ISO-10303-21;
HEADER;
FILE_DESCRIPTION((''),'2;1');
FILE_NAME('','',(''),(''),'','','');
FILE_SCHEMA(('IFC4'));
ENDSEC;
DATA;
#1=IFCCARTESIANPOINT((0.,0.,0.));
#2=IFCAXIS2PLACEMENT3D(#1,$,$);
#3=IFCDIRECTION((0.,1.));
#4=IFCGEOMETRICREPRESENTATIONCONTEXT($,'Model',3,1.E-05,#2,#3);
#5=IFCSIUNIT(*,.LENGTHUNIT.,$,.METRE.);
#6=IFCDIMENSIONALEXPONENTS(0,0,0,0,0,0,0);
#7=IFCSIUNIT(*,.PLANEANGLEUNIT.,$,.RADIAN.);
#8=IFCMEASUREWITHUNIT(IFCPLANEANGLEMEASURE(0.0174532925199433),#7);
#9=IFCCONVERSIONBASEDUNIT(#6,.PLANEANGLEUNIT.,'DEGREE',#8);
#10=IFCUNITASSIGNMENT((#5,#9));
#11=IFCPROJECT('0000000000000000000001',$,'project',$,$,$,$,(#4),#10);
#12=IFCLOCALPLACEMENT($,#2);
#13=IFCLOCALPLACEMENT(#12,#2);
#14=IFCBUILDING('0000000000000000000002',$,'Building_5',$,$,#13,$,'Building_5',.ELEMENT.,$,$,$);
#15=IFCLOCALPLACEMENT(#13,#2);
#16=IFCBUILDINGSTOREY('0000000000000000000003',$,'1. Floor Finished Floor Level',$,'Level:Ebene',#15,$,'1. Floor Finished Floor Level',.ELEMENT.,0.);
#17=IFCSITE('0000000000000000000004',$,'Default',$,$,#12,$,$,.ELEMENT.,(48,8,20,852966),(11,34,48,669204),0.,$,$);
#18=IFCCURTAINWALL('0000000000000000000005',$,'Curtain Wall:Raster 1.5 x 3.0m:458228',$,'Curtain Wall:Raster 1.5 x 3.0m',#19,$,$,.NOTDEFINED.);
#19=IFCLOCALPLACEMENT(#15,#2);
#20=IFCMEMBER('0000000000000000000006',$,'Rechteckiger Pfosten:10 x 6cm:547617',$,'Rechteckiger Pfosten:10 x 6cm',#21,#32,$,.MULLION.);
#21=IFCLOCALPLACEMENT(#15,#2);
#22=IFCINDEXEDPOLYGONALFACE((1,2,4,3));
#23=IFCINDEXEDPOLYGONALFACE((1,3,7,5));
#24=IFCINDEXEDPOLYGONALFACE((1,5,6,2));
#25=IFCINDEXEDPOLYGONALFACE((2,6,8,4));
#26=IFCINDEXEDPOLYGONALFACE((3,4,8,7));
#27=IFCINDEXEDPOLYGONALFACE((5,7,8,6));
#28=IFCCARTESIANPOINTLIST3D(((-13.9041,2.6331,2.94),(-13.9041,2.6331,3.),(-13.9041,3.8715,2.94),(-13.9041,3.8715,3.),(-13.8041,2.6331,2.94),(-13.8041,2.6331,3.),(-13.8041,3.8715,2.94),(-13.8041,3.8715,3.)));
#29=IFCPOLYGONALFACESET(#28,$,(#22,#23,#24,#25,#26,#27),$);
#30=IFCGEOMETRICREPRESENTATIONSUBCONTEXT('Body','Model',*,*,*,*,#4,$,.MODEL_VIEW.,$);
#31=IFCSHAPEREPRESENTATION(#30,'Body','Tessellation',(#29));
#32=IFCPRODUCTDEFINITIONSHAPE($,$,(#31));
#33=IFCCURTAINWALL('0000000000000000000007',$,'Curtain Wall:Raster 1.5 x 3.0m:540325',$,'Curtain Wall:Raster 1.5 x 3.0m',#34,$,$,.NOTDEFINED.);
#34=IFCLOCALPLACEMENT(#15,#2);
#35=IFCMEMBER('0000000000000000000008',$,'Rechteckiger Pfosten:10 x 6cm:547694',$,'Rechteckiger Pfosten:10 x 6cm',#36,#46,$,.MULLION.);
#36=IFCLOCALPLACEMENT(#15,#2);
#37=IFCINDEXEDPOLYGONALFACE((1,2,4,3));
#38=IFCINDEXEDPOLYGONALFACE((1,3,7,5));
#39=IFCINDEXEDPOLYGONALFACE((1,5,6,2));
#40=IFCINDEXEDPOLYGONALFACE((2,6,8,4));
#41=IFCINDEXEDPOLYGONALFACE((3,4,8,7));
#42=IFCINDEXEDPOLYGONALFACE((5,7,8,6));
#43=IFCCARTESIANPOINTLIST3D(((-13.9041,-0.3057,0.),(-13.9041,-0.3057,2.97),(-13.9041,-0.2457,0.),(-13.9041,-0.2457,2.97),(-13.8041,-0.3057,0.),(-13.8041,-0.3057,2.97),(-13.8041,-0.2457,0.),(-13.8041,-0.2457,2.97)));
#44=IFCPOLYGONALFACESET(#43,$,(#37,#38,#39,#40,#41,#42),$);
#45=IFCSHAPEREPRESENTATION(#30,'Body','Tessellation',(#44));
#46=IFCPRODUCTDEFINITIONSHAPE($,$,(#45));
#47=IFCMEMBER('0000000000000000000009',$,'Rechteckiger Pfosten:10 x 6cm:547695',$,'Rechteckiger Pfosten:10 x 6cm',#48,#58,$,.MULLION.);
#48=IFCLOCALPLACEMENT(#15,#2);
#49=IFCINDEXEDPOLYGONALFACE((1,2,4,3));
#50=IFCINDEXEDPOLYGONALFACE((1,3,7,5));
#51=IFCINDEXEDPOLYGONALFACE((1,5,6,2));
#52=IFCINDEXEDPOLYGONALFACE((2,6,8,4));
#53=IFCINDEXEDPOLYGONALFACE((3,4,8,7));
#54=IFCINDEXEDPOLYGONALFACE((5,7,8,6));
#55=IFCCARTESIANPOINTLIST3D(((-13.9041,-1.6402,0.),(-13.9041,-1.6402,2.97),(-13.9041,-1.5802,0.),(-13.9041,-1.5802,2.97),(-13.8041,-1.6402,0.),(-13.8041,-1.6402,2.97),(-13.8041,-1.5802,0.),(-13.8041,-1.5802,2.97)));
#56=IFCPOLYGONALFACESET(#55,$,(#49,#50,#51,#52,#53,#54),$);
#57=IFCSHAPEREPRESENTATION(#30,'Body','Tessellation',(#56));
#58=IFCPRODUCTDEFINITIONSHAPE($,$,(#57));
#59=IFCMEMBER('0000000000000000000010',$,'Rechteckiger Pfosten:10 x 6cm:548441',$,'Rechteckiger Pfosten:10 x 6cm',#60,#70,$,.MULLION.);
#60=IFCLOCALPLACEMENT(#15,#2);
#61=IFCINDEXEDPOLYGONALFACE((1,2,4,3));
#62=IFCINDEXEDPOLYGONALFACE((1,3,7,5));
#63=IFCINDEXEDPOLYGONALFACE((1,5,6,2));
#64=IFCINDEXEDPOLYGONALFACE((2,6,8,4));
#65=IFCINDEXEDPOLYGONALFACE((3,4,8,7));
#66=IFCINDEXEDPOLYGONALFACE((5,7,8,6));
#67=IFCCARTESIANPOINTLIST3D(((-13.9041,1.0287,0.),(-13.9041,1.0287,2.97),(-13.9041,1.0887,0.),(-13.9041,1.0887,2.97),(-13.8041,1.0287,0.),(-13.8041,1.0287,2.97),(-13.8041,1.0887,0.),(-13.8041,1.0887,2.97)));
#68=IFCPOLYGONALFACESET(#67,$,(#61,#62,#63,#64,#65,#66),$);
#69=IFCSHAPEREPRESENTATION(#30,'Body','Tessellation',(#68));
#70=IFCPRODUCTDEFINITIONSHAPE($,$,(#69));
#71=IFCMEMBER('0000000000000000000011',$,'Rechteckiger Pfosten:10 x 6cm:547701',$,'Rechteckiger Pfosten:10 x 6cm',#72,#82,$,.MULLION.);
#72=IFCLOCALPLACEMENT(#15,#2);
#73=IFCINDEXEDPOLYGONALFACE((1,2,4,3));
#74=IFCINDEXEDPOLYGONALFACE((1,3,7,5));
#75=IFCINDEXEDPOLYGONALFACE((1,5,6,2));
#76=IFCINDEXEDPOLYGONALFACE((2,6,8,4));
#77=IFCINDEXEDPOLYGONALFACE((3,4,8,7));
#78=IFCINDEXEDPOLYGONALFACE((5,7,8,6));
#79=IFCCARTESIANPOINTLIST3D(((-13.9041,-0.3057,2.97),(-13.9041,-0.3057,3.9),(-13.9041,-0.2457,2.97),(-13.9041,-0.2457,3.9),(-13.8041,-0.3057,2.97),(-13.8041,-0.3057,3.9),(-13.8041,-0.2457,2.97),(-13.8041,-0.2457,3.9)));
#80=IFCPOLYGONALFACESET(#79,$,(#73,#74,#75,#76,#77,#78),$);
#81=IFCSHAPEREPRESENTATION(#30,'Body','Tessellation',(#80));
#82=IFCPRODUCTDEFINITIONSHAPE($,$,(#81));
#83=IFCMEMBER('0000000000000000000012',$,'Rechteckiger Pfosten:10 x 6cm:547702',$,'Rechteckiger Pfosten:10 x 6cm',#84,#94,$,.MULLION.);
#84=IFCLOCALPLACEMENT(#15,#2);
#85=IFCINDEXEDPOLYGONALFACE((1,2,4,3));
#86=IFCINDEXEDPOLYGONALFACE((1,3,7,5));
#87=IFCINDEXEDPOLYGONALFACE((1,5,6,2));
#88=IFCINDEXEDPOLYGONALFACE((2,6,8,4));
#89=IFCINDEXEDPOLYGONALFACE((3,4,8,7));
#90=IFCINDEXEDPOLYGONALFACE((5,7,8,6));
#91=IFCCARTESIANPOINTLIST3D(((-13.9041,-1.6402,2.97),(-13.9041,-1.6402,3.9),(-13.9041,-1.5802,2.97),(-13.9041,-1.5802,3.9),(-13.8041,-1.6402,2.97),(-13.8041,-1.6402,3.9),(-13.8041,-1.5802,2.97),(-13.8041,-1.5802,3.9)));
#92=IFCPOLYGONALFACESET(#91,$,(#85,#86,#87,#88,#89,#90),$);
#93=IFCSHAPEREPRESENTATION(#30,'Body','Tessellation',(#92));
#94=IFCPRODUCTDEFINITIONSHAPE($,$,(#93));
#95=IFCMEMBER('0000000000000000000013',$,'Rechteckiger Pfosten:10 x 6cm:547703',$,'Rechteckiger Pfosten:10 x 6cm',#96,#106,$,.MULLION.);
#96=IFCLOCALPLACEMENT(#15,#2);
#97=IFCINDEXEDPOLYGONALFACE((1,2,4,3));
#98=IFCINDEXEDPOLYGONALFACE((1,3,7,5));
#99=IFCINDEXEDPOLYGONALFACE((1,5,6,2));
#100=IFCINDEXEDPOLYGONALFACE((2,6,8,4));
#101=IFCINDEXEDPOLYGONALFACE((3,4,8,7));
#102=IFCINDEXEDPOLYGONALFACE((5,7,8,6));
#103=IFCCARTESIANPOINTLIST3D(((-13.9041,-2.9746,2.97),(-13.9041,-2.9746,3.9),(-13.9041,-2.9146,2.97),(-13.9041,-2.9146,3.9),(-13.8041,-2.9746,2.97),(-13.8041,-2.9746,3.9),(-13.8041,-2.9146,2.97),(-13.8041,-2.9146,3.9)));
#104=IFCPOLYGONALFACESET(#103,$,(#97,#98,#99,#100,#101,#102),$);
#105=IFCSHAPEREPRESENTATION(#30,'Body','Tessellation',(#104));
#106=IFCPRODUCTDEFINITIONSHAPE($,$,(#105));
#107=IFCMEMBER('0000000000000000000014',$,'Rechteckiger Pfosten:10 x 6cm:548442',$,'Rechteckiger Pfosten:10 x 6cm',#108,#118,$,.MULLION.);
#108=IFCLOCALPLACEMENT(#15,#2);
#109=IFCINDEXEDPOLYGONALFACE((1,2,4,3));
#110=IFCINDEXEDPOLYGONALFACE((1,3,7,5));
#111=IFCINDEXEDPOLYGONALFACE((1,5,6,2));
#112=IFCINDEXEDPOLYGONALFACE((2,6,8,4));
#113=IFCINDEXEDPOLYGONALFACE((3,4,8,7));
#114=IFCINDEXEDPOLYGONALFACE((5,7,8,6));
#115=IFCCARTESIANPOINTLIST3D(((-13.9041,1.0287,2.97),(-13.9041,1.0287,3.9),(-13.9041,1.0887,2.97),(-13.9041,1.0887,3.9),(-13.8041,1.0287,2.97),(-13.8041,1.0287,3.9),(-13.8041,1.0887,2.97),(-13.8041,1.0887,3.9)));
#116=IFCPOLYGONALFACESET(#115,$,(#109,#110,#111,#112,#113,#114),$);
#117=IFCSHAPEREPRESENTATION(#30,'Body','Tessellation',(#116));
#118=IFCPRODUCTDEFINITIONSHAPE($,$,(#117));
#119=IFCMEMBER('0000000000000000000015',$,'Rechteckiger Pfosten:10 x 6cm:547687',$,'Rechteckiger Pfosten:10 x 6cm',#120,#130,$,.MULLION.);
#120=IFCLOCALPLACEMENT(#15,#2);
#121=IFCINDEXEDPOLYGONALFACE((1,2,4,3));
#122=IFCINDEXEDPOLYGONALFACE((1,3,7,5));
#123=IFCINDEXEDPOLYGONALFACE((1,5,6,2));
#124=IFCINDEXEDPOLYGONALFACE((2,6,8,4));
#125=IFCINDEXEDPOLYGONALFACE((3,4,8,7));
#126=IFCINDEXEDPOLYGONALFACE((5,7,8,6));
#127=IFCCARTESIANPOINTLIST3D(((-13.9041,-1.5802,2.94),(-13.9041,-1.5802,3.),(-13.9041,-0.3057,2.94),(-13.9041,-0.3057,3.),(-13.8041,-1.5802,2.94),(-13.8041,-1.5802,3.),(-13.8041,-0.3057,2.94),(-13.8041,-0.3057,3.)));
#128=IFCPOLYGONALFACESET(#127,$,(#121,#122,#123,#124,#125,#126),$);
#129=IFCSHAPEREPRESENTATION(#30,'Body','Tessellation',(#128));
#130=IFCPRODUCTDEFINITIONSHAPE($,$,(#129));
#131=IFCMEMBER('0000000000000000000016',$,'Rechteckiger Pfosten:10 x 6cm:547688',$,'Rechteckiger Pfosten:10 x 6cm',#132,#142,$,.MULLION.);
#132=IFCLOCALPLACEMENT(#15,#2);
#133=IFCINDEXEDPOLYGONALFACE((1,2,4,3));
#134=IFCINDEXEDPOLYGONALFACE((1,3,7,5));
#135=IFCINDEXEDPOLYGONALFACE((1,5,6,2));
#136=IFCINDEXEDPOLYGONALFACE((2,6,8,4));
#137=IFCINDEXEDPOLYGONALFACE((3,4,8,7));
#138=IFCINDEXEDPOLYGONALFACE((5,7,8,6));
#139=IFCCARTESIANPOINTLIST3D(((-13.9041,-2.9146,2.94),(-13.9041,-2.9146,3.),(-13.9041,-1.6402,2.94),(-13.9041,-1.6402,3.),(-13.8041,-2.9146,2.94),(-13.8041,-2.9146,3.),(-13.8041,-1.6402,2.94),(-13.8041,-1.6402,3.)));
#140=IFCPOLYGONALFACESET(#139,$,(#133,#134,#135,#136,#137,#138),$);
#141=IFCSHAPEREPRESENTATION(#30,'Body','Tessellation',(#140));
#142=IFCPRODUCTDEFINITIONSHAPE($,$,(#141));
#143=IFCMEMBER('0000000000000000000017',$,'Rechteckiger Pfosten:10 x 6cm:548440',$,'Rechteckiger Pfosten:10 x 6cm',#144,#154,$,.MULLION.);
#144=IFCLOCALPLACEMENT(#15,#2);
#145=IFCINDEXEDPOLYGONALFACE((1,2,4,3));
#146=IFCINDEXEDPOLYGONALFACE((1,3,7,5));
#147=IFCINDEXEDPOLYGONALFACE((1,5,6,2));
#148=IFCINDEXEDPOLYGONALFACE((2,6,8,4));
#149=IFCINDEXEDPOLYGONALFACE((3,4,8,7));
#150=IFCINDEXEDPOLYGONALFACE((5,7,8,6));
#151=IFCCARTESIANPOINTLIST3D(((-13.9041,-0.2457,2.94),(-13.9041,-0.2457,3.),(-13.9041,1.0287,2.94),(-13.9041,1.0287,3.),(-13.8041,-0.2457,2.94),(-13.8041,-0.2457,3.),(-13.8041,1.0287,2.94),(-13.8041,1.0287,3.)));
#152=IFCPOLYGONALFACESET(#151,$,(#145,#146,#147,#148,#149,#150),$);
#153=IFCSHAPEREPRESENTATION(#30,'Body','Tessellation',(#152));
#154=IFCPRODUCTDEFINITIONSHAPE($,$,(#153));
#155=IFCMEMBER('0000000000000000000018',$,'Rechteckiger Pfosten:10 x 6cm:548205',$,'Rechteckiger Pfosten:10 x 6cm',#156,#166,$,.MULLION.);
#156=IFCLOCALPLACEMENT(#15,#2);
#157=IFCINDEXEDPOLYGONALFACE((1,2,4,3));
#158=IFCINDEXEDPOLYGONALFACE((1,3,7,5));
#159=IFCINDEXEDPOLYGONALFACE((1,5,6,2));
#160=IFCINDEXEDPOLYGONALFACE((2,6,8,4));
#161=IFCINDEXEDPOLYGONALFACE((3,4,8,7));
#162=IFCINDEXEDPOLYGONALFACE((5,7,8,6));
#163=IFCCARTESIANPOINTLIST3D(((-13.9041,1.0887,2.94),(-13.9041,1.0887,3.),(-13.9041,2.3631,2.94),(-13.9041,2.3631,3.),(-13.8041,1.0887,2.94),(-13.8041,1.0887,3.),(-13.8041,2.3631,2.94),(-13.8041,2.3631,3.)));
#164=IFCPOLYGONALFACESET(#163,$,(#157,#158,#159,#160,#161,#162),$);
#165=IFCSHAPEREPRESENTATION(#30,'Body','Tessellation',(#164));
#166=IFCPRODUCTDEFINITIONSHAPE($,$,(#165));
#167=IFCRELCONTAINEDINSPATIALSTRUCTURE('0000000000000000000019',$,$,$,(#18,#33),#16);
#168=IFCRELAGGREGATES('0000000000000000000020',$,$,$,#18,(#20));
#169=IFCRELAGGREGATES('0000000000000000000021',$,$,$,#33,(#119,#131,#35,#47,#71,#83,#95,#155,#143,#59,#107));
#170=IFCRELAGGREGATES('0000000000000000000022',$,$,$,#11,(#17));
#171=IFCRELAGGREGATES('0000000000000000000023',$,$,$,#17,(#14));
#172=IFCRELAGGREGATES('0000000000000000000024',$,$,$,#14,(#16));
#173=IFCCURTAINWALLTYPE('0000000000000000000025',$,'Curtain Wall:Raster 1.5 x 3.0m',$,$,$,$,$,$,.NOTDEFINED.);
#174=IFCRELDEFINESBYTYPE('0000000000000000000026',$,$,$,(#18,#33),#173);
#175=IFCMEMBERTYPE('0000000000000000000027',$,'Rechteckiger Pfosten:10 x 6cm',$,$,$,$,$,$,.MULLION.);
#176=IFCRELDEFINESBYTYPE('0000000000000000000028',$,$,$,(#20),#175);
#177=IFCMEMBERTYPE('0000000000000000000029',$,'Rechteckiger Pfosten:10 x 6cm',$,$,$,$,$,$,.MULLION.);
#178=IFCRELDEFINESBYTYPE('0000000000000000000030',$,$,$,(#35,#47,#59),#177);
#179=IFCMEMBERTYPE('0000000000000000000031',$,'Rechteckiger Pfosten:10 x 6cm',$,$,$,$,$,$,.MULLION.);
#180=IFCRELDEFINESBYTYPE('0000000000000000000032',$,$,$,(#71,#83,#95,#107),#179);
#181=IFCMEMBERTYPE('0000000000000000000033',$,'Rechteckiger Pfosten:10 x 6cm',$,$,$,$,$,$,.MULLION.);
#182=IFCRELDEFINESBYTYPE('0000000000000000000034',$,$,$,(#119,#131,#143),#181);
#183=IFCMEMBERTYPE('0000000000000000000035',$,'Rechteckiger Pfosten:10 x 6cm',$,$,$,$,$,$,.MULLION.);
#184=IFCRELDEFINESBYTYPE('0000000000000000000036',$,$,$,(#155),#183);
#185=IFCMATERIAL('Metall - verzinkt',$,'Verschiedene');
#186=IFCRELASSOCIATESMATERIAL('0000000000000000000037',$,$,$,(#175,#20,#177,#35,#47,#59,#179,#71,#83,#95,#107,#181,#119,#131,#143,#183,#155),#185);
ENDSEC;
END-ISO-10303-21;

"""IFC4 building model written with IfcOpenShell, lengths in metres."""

from ifc_helpers import new_model, entity, si_unit, converted_unit, direction, frame, origin, place, context, subcontext, project, spatial, indexed_curve, outline, extrude, source, transform, mapped, material, type_object, type_shapes, element, aggregate, save


model = new_model("IFC4")

# Units and contexts
model_context = context("Model", 3, precision=1e-05, world=origin(), true_north=direction((0.0, 1.0)))
body_context = subcontext(model_context, "Body", "Model", "MODEL_VIEW")
ifc_project = project(units=[si_unit("LENGTHUNIT", "METRE"), converted_unit("PLANEANGLEUNIT", "DEGREE", entity("IfcPlaneAngleMeasure", 0.0174532925199433), si_unit("PLANEANGLEUNIT", "RADIAN"), dimensions=[0, 0, 0, 0, 0, 0, 0])], contexts=[model_context])

# Site, building, storey
site_placement = place(None, origin())
site = spatial("IfcSite", under=ifc_project, at=site_placement, Name="Default", CompositionType="ELEMENT", RefLatitude=(48, 8, 20, 852966), RefLongitude=(11, 34, 48, 669204), RefElevation=0.0)
building_placement = place(site_placement, origin())
building = spatial("IfcBuilding", under=site, at=building_placement, Name="Building_5", LongName="Building_5", CompositionType="ELEMENT")
storey_placement = place(building_placement, origin())
storey = spatial("IfcBuildingStorey", under=building, at=storey_placement, Name="1. Floor Finished Floor Level", ObjectType="Level:Ebene", LongName="1. Floor Finished Floor Level", CompositionType="ELEMENT", Elevation=0.0)

# Curtain wall, member
curtain_wall_type = type_object("IfcCurtainWallType", Name="Curtain Wall:Raster 1.5 x 3.0m", PredefinedType="NOTDEFINED")
curtain_wall_1_placement = place(storey_placement, origin())
curtain_wall_1 = element("IfcCurtainWall", 1, at=curtain_wall_1_placement, inside=storey, type_object=curtain_wall_type, Name="Curtain Wall:Raster 1.5 x 3.0m:458228", ObjectType="Curtain Wall:Raster 1.5 x 3.0m", PredefinedType="NOTDEFINED")
ifc_material_1 = material(Name="Metall - verzinkt", Category="Verschiedene")
member_type_1 = type_object("IfcMemberType", Name="Rechteckiger Pfosten:10 x 6cm", PredefinedType="MULLION", material=ifc_material_1)
shared_shape_1 = source(origin(), body_context, "Body", "SweptSolid", [
    extrude(outline(indexed_curve([(-0.03, -0.05), (0.03, -0.05), (0.03, 0.05), (-0.03, 0.05), (-0.03, -0.05)], self_intersect=False)), frame((0.0, 0.0, -1.2383), z_axis=(0.0, 0.0, 1.0), x_axis=(-1.0, 0.0, 0.0)), (0.0, 0.0, 1.0), 1.2383),
])
type_shapes(member_type_1, [shared_shape_1])
member_1_placement = place(curtain_wall_1_placement, frame((-13.8541, 2.6331, 2.97), z_axis=(0.0, -1.0, 0.0), x_axis=(0.0, 0.0, 1.0)))
member_1 = element("IfcMember", 2, at=member_1_placement, type_object=member_type_1, material=ifc_material_1, Name="Rechteckiger Pfosten:10 x 6cm:547617", ObjectType="Rechteckiger Pfosten:10 x 6cm", PredefinedType="MULLION", context=body_context, shape_type="MappedRepresentation", body=[
    mapped(shared_shape_1, transform((0.0, 0.0, 0.0), scale=1.0)),
])

# Curtain wall, members
curtain_wall_2_placement = place(storey_placement, origin())
curtain_wall_2 = element("IfcCurtainWall", 3, at=curtain_wall_2_placement, inside=storey, type_object=curtain_wall_type, Name="Curtain Wall:Raster 1.5 x 3.0m:540325", ObjectType="Curtain Wall:Raster 1.5 x 3.0m", PredefinedType="NOTDEFINED")
member_type_2 = type_object("IfcMemberType", Name="Rechteckiger Pfosten:10 x 6cm", PredefinedType="MULLION", material=ifc_material_1)
shared_shape_2 = source(origin(), body_context, "Body", "SweptSolid", [
    extrude(outline(indexed_curve([(-0.03, -0.05), (0.03, -0.05), (0.03, 0.05), (-0.03, 0.05), (-0.03, -0.05)], self_intersect=False)), frame((0.0, 0.0, -2.97), z_axis=(0.0, 0.0, 1.0), x_axis=(-1.0, 0.0, 0.0)), (0.0, 0.0, 1.0), 2.97),
])
type_shapes(member_type_2, [shared_shape_2])
member_2_placement = place(curtain_wall_2_placement, frame((-13.8541, -0.2757, 0.0), z_axis=(0.0, 0.0, -1.0), x_axis=(0.0, -1.0, 0.0)))
member_2 = element("IfcMember", 4, at=member_2_placement, type_object=member_type_2, material=ifc_material_1, Name="Rechteckiger Pfosten:10 x 6cm:547694", ObjectType="Rechteckiger Pfosten:10 x 6cm", PredefinedType="MULLION", context=body_context, shape_type="MappedRepresentation", body=[
    mapped(shared_shape_2, transform((0.0, 0.0, 0.0), scale=1.0)),
])
member_3_placement = place(curtain_wall_2_placement, frame((-13.8541, -1.6102, 0.0), z_axis=(0.0, 0.0, -1.0), x_axis=(0.0, -1.0, 0.0)))
member_3 = element("IfcMember", 5, at=member_3_placement, type_object=member_type_2, material=ifc_material_1, Name="Rechteckiger Pfosten:10 x 6cm:547695", ObjectType="Rechteckiger Pfosten:10 x 6cm", PredefinedType="MULLION", context=body_context, shape_type="MappedRepresentation", body=[
    mapped(shared_shape_2, transform((0.0, 0.0, 0.0), scale=1.0)),
])
member_4_placement = place(curtain_wall_2_placement, frame((-13.8541, 1.0587, 0.0), z_axis=(0.0, 0.0, -1.0), x_axis=(0.0, -1.0, 0.0)))
member_4 = element("IfcMember", 6, at=member_4_placement, type_object=member_type_2, material=ifc_material_1, Name="Rechteckiger Pfosten:10 x 6cm:548441", ObjectType="Rechteckiger Pfosten:10 x 6cm", PredefinedType="MULLION", context=body_context, shape_type="MappedRepresentation", body=[
    mapped(shared_shape_2, transform((0.0, 0.0, 0.0), scale=1.0)),
])
member_type_3 = type_object("IfcMemberType", Name="Rechteckiger Pfosten:10 x 6cm", PredefinedType="MULLION", material=ifc_material_1)
shared_shape_3 = source(origin(), body_context, "Body", "SweptSolid", [
    extrude(outline(indexed_curve([(-0.03, -0.05), (0.03, -0.05), (0.03, 0.05), (-0.03, 0.05), (-0.03, -0.05)], self_intersect=False)), frame((0.0, 0.0, -0.93), z_axis=(0.0, 0.0, 1.0), x_axis=(-1.0, 0.0, 0.0)), (0.0, 0.0, 1.0), 0.93),
])
type_shapes(member_type_3, [shared_shape_3])
member_5_placement = place(curtain_wall_2_placement, frame((-13.8541, -0.2757, 2.97), z_axis=(0.0, 0.0, -1.0), x_axis=(0.0, -1.0, 0.0)))
member_5 = element("IfcMember", 7, at=member_5_placement, type_object=member_type_3, material=ifc_material_1, Name="Rechteckiger Pfosten:10 x 6cm:547701", ObjectType="Rechteckiger Pfosten:10 x 6cm", PredefinedType="MULLION", context=body_context, shape_type="MappedRepresentation", body=[
    mapped(shared_shape_3, transform((0.0, 0.0, 0.0), scale=1.0)),
])
member_6_placement = place(curtain_wall_2_placement, frame((-13.8541, -1.6102, 2.97), z_axis=(0.0, 0.0, -1.0), x_axis=(0.0, -1.0, 0.0)))
member_6 = element("IfcMember", 8, at=member_6_placement, type_object=member_type_3, material=ifc_material_1, Name="Rechteckiger Pfosten:10 x 6cm:547702", ObjectType="Rechteckiger Pfosten:10 x 6cm", PredefinedType="MULLION", context=body_context, shape_type="MappedRepresentation", body=[
    mapped(shared_shape_3, transform((0.0, 0.0, 0.0), scale=1.0)),
])
member_7_placement = place(curtain_wall_2_placement, frame((-13.8541, -2.9446, 2.97), z_axis=(0.0, 0.0, -1.0), x_axis=(0.0, -1.0, 0.0)))
member_7 = element("IfcMember", 9, at=member_7_placement, type_object=member_type_3, material=ifc_material_1, Name="Rechteckiger Pfosten:10 x 6cm:547703", ObjectType="Rechteckiger Pfosten:10 x 6cm", PredefinedType="MULLION", context=body_context, shape_type="MappedRepresentation", body=[
    mapped(shared_shape_3, transform((0.0, 0.0, 0.0), scale=1.0)),
])
member_8_placement = place(curtain_wall_2_placement, frame((-13.8541, 1.0587, 2.97), z_axis=(0.0, 0.0, -1.0), x_axis=(0.0, -1.0, 0.0)))
member_8 = element("IfcMember", 10, at=member_8_placement, type_object=member_type_3, material=ifc_material_1, Name="Rechteckiger Pfosten:10 x 6cm:548442", ObjectType="Rechteckiger Pfosten:10 x 6cm", PredefinedType="MULLION", context=body_context, shape_type="MappedRepresentation", body=[
    mapped(shared_shape_3, transform((0.0, 0.0, 0.0), scale=1.0)),
])
member_type_4 = type_object("IfcMemberType", Name="Rechteckiger Pfosten:10 x 6cm", PredefinedType="MULLION", material=ifc_material_1)
shared_shape_4 = source(origin(), body_context, "Body", "SweptSolid", [
    extrude(outline(indexed_curve([(-0.03, -0.05), (0.03, -0.05), (0.03, 0.05), (-0.03, 0.05), (-0.03, -0.05)], self_intersect=False)), frame((0.0, 0.0, -1.2744), z_axis=(0.0, 0.0, 1.0), x_axis=(-1.0, 0.0, 0.0)), (0.0, 0.0, 1.0), 1.2744),
])
type_shapes(member_type_4, [shared_shape_4])
member_9_placement = place(curtain_wall_2_placement, frame((-13.8541, -1.5802, 2.97), z_axis=(0.0, -1.0, 0.0), x_axis=(0.0, 0.0, 1.0)))
member_9 = element("IfcMember", 11, at=member_9_placement, type_object=member_type_4, material=ifc_material_1, Name="Rechteckiger Pfosten:10 x 6cm:547687", ObjectType="Rechteckiger Pfosten:10 x 6cm", PredefinedType="MULLION", context=body_context, shape_type="MappedRepresentation", body=[
    mapped(shared_shape_4, transform((0.0, 0.0, 0.0), scale=1.0)),
])
member_10_placement = place(curtain_wall_2_placement, frame((-13.8541, -2.9146, 2.97), z_axis=(0.0, -1.0, 0.0), x_axis=(0.0, 0.0, 1.0)))
member_10 = element("IfcMember", 12, at=member_10_placement, type_object=member_type_4, material=ifc_material_1, Name="Rechteckiger Pfosten:10 x 6cm:547688", ObjectType="Rechteckiger Pfosten:10 x 6cm", PredefinedType="MULLION", context=body_context, shape_type="MappedRepresentation", body=[
    mapped(shared_shape_4, transform((0.0, 0.0, 0.0), scale=1.0)),
])
member_11_placement = place(curtain_wall_2_placement, frame((-13.8541, -0.2457, 2.97), z_axis=(0.0, -1.0, 0.0), x_axis=(0.0, 0.0, 1.0)))
member_11 = element("IfcMember", 13, at=member_11_placement, type_object=member_type_4, material=ifc_material_1, Name="Rechteckiger Pfosten:10 x 6cm:548440", ObjectType="Rechteckiger Pfosten:10 x 6cm", PredefinedType="MULLION", context=body_context, shape_type="MappedRepresentation", body=[
    mapped(shared_shape_4, transform((0.0, 0.0, 0.0), scale=1.0)),
])
member_type_5 = type_object("IfcMemberType", Name="Rechteckiger Pfosten:10 x 6cm", PredefinedType="MULLION", material=ifc_material_1)
shared_shape_5 = source(origin(), body_context, "Body", "SweptSolid", [
    extrude(outline(indexed_curve([(-0.03, -0.05), (0.03, -0.05), (0.03, 0.05), (-0.03, 0.05), (-0.03, -0.05)], self_intersect=False)), frame((0.0, 0.0, -1.2744), z_axis=(0.0, 0.0, 1.0), x_axis=(-1.0, 0.0, 0.0)), (0.0, 0.0, 1.0), 1.2744),
])
type_shapes(member_type_5, [shared_shape_5])
member_12_placement = place(curtain_wall_2_placement, frame((-13.8541, 1.0887, 2.97), z_axis=(0.0, -1.0, 0.0), x_axis=(0.0, 0.0, 1.0)))
member_12 = element("IfcMember", 14, at=member_12_placement, type_object=member_type_5, material=ifc_material_1, Name="Rechteckiger Pfosten:10 x 6cm:548205", ObjectType="Rechteckiger Pfosten:10 x 6cm", PredefinedType="MULLION", context=body_context, shape_type="MappedRepresentation", body=[
    mapped(shared_shape_5, transform((0.0, 0.0, 0.0), scale=1.0)),
])

aggregate(curtain_wall_1, [member_1])
aggregate(curtain_wall_2, [member_9, member_10, member_2, member_3, member_5, member_6, member_7, member_12, member_11, member_4, member_8])

save(model, "model.ifc")
